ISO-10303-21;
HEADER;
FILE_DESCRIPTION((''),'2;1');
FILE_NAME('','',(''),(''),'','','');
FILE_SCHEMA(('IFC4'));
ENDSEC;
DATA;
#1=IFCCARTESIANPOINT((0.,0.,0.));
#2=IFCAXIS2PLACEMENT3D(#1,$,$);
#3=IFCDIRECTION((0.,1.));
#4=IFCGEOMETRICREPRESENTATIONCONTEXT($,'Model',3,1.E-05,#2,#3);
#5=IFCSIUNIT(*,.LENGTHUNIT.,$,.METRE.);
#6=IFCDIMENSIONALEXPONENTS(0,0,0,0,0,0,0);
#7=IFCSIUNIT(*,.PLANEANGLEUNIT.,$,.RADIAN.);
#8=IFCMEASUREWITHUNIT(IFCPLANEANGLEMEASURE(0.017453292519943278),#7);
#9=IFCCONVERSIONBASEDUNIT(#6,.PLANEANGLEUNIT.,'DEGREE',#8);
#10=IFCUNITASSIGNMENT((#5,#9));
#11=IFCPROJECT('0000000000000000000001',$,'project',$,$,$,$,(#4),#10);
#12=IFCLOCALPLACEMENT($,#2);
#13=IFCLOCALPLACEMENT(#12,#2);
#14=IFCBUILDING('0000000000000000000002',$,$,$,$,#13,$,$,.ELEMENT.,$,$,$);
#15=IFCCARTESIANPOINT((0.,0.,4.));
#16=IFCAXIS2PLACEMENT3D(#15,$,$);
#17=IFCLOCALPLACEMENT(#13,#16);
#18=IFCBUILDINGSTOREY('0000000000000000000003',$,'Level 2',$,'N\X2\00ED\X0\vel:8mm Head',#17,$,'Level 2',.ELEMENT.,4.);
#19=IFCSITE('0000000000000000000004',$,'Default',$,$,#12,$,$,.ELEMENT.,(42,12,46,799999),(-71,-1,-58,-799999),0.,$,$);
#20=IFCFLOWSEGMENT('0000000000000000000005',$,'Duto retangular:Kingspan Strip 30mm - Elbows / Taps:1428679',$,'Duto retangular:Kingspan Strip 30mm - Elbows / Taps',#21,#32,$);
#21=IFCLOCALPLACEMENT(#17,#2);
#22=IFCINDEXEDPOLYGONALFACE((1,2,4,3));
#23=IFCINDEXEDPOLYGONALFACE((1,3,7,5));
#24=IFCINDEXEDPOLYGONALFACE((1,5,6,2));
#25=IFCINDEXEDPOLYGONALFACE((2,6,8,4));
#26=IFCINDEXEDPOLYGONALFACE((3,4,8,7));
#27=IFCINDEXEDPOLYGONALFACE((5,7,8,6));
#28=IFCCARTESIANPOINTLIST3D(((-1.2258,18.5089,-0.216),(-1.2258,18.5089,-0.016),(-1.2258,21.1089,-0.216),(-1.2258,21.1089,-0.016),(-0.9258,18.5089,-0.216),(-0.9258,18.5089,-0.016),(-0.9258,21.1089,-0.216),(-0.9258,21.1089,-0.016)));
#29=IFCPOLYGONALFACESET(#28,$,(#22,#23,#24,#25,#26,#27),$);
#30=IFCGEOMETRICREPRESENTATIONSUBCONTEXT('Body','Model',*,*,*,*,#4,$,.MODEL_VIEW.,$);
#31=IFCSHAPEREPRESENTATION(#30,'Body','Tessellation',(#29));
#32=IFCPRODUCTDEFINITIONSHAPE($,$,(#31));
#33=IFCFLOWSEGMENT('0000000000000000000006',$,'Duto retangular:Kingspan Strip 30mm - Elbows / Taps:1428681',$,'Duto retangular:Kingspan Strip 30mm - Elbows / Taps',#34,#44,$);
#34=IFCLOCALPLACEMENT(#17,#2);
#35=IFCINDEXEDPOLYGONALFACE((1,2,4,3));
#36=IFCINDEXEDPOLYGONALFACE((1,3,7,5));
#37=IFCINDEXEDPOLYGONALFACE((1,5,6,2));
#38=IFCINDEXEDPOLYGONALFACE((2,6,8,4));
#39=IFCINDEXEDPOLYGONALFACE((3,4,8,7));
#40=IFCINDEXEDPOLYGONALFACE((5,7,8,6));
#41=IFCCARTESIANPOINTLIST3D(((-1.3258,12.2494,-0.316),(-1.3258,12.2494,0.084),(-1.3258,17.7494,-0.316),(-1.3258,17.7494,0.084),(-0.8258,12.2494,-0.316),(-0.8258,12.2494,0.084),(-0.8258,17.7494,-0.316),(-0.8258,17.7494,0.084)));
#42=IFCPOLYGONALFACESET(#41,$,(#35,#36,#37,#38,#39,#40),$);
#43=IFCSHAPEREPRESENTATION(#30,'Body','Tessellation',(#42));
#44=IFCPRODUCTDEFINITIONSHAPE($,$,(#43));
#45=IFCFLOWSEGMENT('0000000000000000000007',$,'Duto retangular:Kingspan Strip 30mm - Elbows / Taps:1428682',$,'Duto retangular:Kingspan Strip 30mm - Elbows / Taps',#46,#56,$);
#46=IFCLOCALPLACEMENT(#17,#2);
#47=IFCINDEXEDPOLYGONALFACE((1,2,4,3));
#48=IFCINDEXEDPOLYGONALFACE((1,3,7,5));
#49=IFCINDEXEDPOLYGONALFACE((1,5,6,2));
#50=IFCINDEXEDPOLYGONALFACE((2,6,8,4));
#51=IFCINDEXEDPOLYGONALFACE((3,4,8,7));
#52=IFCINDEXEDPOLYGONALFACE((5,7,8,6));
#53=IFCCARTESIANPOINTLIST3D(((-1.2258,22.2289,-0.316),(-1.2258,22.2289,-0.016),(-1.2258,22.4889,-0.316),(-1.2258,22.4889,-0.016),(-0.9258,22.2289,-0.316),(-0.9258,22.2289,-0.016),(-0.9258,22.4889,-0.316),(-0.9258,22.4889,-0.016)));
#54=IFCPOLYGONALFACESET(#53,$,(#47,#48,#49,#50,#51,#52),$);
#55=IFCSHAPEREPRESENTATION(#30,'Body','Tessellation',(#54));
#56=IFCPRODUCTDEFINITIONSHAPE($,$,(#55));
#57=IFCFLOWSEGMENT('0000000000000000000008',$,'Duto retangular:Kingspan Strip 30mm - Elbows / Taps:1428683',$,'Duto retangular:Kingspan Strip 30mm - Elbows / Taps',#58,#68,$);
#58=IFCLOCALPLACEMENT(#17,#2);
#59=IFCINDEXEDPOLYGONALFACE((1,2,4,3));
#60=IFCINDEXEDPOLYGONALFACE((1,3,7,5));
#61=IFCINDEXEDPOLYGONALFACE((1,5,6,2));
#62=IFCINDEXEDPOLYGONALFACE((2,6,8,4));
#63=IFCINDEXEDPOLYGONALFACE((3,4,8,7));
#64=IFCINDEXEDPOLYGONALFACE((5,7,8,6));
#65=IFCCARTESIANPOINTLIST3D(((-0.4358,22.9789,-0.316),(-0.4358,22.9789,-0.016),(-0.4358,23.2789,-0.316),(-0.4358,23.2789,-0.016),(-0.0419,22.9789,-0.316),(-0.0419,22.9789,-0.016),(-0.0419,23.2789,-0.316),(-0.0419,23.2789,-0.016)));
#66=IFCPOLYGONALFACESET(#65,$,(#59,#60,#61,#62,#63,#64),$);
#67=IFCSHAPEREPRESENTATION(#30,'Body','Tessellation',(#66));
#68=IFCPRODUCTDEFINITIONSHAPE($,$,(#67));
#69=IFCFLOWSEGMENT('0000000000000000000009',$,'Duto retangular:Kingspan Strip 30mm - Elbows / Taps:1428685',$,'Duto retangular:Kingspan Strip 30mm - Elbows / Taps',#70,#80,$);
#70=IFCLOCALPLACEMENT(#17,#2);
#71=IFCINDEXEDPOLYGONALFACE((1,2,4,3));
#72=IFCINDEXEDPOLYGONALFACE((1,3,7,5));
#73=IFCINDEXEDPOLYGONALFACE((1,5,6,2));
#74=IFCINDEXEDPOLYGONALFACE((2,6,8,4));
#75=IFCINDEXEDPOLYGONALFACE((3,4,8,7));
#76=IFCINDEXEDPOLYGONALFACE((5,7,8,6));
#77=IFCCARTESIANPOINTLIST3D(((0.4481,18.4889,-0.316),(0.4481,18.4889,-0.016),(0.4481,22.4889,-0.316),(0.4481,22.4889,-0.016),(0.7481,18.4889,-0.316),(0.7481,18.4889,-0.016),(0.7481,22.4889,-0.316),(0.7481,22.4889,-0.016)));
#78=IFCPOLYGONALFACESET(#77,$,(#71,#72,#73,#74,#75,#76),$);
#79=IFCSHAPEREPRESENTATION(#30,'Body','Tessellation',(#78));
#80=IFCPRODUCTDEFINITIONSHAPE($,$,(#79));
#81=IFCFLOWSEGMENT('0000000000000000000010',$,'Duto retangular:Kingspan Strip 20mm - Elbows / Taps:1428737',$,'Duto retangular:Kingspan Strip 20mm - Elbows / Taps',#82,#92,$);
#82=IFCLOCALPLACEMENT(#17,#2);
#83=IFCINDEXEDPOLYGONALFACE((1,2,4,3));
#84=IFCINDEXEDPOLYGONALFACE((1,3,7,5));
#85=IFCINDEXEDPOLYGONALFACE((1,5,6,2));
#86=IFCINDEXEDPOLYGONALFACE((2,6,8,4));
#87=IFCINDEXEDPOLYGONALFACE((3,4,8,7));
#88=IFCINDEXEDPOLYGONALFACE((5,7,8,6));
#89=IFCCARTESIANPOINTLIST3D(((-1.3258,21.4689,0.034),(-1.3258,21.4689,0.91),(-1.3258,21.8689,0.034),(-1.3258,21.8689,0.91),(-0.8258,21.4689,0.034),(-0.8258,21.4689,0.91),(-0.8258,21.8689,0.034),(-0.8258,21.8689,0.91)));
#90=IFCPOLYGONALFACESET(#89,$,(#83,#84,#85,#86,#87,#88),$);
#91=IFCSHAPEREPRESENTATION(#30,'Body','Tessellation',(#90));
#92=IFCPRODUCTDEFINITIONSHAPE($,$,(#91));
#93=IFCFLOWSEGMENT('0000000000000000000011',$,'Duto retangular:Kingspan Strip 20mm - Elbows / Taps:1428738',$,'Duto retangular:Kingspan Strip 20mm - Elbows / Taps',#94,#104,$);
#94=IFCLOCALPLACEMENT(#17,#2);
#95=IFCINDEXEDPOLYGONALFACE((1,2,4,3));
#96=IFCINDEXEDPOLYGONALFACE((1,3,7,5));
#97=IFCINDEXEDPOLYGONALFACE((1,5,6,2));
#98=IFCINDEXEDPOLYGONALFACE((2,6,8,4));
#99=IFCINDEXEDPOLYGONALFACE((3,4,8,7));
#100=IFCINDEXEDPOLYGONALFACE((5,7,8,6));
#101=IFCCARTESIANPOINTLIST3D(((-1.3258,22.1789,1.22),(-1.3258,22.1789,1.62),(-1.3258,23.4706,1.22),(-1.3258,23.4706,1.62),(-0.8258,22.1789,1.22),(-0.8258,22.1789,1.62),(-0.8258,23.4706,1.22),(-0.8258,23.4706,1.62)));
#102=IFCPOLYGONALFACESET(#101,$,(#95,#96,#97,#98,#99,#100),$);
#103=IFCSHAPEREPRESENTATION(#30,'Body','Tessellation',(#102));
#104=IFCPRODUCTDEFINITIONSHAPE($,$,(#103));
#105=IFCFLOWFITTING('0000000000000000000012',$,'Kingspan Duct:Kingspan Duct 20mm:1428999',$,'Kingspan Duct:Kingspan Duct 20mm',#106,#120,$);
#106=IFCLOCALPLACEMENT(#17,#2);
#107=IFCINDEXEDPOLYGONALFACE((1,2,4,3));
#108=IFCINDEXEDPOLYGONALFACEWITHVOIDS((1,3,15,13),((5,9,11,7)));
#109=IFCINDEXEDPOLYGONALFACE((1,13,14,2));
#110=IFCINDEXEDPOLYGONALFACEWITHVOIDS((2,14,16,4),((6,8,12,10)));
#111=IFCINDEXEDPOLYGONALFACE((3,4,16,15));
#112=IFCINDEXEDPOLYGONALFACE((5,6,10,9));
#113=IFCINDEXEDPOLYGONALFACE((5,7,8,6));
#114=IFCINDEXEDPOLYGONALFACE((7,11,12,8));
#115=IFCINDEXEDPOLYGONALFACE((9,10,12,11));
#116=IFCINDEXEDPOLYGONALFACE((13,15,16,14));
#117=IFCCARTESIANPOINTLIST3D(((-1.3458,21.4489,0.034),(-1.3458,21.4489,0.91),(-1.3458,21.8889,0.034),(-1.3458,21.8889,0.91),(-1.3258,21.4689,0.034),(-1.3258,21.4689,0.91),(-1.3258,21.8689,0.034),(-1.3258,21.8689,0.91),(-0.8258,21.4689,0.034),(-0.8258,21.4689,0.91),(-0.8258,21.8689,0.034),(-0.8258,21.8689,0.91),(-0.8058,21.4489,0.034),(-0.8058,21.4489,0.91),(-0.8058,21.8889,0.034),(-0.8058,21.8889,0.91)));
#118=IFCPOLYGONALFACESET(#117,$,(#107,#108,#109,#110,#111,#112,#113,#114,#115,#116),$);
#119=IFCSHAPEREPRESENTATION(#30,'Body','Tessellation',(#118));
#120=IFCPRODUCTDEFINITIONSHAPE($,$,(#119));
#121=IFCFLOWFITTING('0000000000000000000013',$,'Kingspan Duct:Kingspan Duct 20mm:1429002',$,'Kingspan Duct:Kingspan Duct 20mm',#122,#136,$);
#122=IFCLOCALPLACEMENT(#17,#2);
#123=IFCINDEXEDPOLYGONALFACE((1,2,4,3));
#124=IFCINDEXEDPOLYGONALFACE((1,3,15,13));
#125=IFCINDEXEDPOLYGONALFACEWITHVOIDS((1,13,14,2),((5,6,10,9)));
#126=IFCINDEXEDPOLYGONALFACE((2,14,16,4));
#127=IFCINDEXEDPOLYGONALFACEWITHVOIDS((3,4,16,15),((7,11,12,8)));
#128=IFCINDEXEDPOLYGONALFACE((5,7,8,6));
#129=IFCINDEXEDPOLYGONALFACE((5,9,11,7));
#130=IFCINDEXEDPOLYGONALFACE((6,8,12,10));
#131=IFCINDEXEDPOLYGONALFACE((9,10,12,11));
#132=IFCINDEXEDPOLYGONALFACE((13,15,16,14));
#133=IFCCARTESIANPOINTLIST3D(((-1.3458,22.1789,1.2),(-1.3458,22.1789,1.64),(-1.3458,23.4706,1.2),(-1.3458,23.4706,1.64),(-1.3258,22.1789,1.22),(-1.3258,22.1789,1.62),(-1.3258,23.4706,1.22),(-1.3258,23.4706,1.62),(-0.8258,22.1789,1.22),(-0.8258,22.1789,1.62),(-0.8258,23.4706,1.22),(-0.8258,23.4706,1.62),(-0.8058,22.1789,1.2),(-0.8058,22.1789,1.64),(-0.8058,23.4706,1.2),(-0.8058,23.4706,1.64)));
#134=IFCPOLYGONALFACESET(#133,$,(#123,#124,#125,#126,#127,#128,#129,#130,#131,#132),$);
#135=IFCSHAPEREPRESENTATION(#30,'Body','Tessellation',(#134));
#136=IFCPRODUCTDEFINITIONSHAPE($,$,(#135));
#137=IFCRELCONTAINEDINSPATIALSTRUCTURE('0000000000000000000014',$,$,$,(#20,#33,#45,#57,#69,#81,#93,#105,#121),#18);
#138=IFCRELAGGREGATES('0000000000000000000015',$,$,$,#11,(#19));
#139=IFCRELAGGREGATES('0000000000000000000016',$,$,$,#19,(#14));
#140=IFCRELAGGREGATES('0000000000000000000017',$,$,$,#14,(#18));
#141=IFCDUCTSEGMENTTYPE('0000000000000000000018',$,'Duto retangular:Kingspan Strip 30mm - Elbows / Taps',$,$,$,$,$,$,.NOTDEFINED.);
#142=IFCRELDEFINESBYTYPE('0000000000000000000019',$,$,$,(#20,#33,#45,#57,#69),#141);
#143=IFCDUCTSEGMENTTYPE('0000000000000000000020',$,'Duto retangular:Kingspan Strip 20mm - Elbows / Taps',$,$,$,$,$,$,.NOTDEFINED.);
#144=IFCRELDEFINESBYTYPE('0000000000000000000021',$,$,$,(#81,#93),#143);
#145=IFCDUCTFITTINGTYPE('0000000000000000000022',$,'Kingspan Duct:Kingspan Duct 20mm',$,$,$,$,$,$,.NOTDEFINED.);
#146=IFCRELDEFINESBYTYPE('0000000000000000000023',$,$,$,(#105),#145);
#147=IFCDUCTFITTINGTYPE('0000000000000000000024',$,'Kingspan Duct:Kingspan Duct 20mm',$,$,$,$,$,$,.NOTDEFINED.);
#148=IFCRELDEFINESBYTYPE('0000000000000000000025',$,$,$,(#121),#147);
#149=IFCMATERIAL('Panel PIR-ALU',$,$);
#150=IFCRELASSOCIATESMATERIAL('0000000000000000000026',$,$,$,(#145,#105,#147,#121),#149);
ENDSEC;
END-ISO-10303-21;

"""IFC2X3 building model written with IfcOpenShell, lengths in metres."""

from ifc_helpers import new_model, entity, si_unit, converted_unit, direction, frame, frame_2d, origin, origin_2d_with_axis, place, context, subcontext, project, spatial, polyline, rectangle, outline, extrude, source, transform, mapped, material, type_object, type_shapes, element, save


model = new_model("IFC2X3")

# Units and contexts
model_context = context("Model", 3, precision=1e-05, world=origin(), true_north=direction((0.0, 1.0)))
body_context = subcontext(model_context, "Body", "Model", "MODEL_VIEW")
ifc_project = project(units=[si_unit("LENGTHUNIT", "METRE"), converted_unit("PLANEANGLEUNIT", "DEGREE", entity("IfcPlaneAngleMeasure", 0.017453292519943278), si_unit("PLANEANGLEUNIT", "RADIAN"), dimensions=[0, 0, 0, 0, 0, 0, 0])], contexts=[model_context])

# Site, building, storey
site_placement = place(None, origin())
site = spatial("IfcSite", under=ifc_project, at=site_placement, Name="Default", CompositionType="ELEMENT", RefLatitude=(42, 12, 46, 799999), RefLongitude=(-71, -1, -58, -799999), RefElevation=0.0)
building_placement = place(site_placement, origin())
building = spatial("IfcBuilding", under=site, at=building_placement, CompositionType="ELEMENT")
storey_placement = place(building_placement, frame((0.0, 0.0, 4.0)))
storey = spatial("IfcBuildingStorey", under=building, at=storey_placement, Name="Level 2", ObjectType="Nível:8mm Head", LongName="Level 2", CompositionType="ELEMENT", Elevation=4.0)

# Flow segments
duct_segment_type_1 = type_object("IfcDuctSegmentType", Name="Duto retangular:Kingspan Strip 30mm - Elbows / Taps", PredefinedType="NOTDEFINED")
flow_segment_1_placement = place(storey_placement, origin())
element("IfcFlowSegment", 1, at=flow_segment_1_placement, inside=storey, type_object=duct_segment_type_1, Name="Duto retangular:Kingspan Strip 30mm - Elbows / Taps:1428679", ObjectType="Duto retangular:Kingspan Strip 30mm - Elbows / Taps", context=body_context, shape_type="SweptSolid", body=[
    extrude(rectangle(XDim=2.6, YDim=0.3, at=frame_2d((0.0, 0.0), x_axis=(1.0, 0.0))), frame((-1.0758, 19.8089, -0.216), z_axis=(0.0, 0.0, 1.0), x_axis=(0.0, -1.0, 0.0)), (0.0, 0.0, 1.0), 0.2),
])
flow_segment_2_placement = place(storey_placement, origin())
element("IfcFlowSegment", 2, at=flow_segment_2_placement, inside=storey, type_object=duct_segment_type_1, Name="Duto retangular:Kingspan Strip 30mm - Elbows / Taps:1428681", ObjectType="Duto retangular:Kingspan Strip 30mm - Elbows / Taps", context=body_context, shape_type="SweptSolid", body=[
    extrude(rectangle(XDim=5.5, YDim=0.5, at=origin_2d_with_axis()), frame((-1.0758, 14.9994, -0.316), z_axis=(0.0, 0.0, 1.0), x_axis=(0.0, -1.0, 0.0)), (0.0, 0.0, 1.0), 0.4),
])
flow_segment_3_placement = place(storey_placement, origin())
element("IfcFlowSegment", 3, at=flow_segment_3_placement, inside=storey, type_object=duct_segment_type_1, Name="Duto retangular:Kingspan Strip 30mm - Elbows / Taps:1428682", ObjectType="Duto retangular:Kingspan Strip 30mm - Elbows / Taps", context=body_context, shape_type="SweptSolid", body=[
    extrude(rectangle(XDim=0.26, YDim=0.3, at=frame_2d((0.0, 0.0), x_axis=(1.0, 0.0))), frame((-1.0758, 22.3589, -0.316), z_axis=(0.0, 0.0, 1.0), x_axis=(0.0, 1.0, 0.0)), (0.0, 0.0, 1.0), 0.3),
])
flow_segment_4_placement = place(storey_placement, origin())
element("IfcFlowSegment", 4, at=flow_segment_4_placement, inside=storey, type_object=duct_segment_type_1, Name="Duto retangular:Kingspan Strip 30mm - Elbows / Taps:1428683", ObjectType="Duto retangular:Kingspan Strip 30mm - Elbows / Taps", context=body_context, shape_type="SweptSolid", body=[
    extrude(rectangle(XDim=0.3939, YDim=0.3, at=origin_2d_with_axis()), frame((-0.2388, 23.1289, -0.316)), (0.0, 0.0, 1.0), 0.3),
])
flow_segment_5_placement = place(storey_placement, origin())
element("IfcFlowSegment", 5, at=flow_segment_5_placement, inside=storey, type_object=duct_segment_type_1, Name="Duto retangular:Kingspan Strip 30mm - Elbows / Taps:1428685", ObjectType="Duto retangular:Kingspan Strip 30mm - Elbows / Taps", context=body_context, shape_type="SweptSolid", body=[
    extrude(rectangle(XDim=4.0, YDim=0.3, at=frame_2d((0.0, 0.0), x_axis=(1.0, 0.0))), frame((0.5981, 20.4889, -0.316), z_axis=(0.0, 0.0, 1.0), x_axis=(0.0, -1.0, 0.0)), (0.0, 0.0, 1.0), 0.3),
])
duct_segment_type_2 = type_object("IfcDuctSegmentType", Name="Duto retangular:Kingspan Strip 20mm - Elbows / Taps", PredefinedType="NOTDEFINED")
flow_segment_6_placement = place(storey_placement, origin())
element("IfcFlowSegment", 6, at=flow_segment_6_placement, inside=storey, type_object=duct_segment_type_2, Name="Duto retangular:Kingspan Strip 20mm - Elbows / Taps:1428737", ObjectType="Duto retangular:Kingspan Strip 20mm - Elbows / Taps", context=body_context, shape_type="SweptSolid", body=[
    extrude(rectangle(XDim=0.5, YDim=0.4, at=origin_2d_with_axis()), frame((-1.0758, 21.6689, 0.034)), (0.0, 0.0, 1.0), 0.876),
])
flow_segment_7_placement = place(storey_placement, origin())
element("IfcFlowSegment", 7, at=flow_segment_7_placement, inside=storey, type_object=duct_segment_type_2, Name="Duto retangular:Kingspan Strip 20mm - Elbows / Taps:1428738", ObjectType="Duto retangular:Kingspan Strip 20mm - Elbows / Taps", context=body_context, shape_type="SweptSolid", body=[
    extrude(rectangle(XDim=1.2917, YDim=0.5, at=origin_2d_with_axis()), frame((-1.0758, 22.8248, 1.22), z_axis=(0.0, 0.0, 1.0), x_axis=(0.0, 1.0, 0.0)), (0.0, 0.0, 1.0), 0.4),
])

# Flow fittings
ifc_material = material(Name="Panel PIR-ALU")
duct_fitting_type_1 = type_object("IfcDuctFittingType", Name="Kingspan Duct:Kingspan Duct 20mm", PredefinedType="NOTDEFINED", material=ifc_material)
shared_shape_1 = source(origin(), body_context, "Body", "SweptSolid", [
    extrude(outline(polyline([(-0.22, -0.27), (0.22, -0.27), (0.22, 0.27), (-0.22, 0.27), (-0.22, -0.27)]), holes=[polyline([(-0.2, -0.25), (-0.2, 0.25), (0.2, 0.25), (0.2, -0.25), (-0.2, -0.25)])]), frame((0.0, 0.0, -0.25), z_axis=(1.0, 0.0, 0.0), x_axis=(0.0, -1.0, 0.0)), (0.0, 0.0, 1.0), 0.876),
])
type_shapes(duct_fitting_type_1, [shared_shape_1])
flow_fitting_1_placement = place(storey_placement, frame((-1.3258, 21.6689, 0.034), z_axis=(-1.0, 0.0, 0.0), x_axis=(0.0, 0.0, 1.0)))
element("IfcFlowFitting", 8, at=flow_fitting_1_placement, inside=storey, type_object=duct_fitting_type_1, material=ifc_material, Name="Kingspan Duct:Kingspan Duct 20mm:1428999", ObjectType="Kingspan Duct:Kingspan Duct 20mm", context=body_context, shape_type="MappedRepresentation", body=[
    mapped(shared_shape_1, transform((0.0, 0.0, 0.0), scale=1.0)),
])
duct_fitting_type_2 = type_object("IfcDuctFittingType", Name="Kingspan Duct:Kingspan Duct 20mm", PredefinedType="NOTDEFINED", material=ifc_material)
shared_shape_2 = source(origin(), body_context, "Body", "SweptSolid", [
    extrude(outline(polyline([(-0.27, -0.22), (0.27, -0.22), (0.27, 0.22), (-0.27, 0.22), (-0.27, -0.22)]), holes=[polyline([(-0.25, -0.2), (-0.25, 0.2), (0.25, 0.2), (0.25, -0.2), (-0.25, -0.2)])]), frame((0.0, 0.0, -0.2), z_axis=(1.0, 0.0, 0.0), x_axis=(0.0, -1.0, 0.0)), (0.0, 0.0, 1.0), 1.2917),
])
type_shapes(duct_fitting_type_2, [shared_shape_2])
flow_fitting_2_placement = place(storey_placement, frame((-1.0758, 22.1789, 1.22), z_axis=(0.0, 0.0, -1.0), x_axis=(0.0, 1.0, 0.0)))
element("IfcFlowFitting", 9, at=flow_fitting_2_placement, inside=storey, type_object=duct_fitting_type_2, material=ifc_material, Name="Kingspan Duct:Kingspan Duct 20mm:1429002", ObjectType="Kingspan Duct:Kingspan Duct 20mm", context=body_context, shape_type="MappedRepresentation", body=[
    mapped(shared_shape_2, transform((0.0, 0.0, 0.0), scale=1.0)),
])

save(model, "model.ifc")
